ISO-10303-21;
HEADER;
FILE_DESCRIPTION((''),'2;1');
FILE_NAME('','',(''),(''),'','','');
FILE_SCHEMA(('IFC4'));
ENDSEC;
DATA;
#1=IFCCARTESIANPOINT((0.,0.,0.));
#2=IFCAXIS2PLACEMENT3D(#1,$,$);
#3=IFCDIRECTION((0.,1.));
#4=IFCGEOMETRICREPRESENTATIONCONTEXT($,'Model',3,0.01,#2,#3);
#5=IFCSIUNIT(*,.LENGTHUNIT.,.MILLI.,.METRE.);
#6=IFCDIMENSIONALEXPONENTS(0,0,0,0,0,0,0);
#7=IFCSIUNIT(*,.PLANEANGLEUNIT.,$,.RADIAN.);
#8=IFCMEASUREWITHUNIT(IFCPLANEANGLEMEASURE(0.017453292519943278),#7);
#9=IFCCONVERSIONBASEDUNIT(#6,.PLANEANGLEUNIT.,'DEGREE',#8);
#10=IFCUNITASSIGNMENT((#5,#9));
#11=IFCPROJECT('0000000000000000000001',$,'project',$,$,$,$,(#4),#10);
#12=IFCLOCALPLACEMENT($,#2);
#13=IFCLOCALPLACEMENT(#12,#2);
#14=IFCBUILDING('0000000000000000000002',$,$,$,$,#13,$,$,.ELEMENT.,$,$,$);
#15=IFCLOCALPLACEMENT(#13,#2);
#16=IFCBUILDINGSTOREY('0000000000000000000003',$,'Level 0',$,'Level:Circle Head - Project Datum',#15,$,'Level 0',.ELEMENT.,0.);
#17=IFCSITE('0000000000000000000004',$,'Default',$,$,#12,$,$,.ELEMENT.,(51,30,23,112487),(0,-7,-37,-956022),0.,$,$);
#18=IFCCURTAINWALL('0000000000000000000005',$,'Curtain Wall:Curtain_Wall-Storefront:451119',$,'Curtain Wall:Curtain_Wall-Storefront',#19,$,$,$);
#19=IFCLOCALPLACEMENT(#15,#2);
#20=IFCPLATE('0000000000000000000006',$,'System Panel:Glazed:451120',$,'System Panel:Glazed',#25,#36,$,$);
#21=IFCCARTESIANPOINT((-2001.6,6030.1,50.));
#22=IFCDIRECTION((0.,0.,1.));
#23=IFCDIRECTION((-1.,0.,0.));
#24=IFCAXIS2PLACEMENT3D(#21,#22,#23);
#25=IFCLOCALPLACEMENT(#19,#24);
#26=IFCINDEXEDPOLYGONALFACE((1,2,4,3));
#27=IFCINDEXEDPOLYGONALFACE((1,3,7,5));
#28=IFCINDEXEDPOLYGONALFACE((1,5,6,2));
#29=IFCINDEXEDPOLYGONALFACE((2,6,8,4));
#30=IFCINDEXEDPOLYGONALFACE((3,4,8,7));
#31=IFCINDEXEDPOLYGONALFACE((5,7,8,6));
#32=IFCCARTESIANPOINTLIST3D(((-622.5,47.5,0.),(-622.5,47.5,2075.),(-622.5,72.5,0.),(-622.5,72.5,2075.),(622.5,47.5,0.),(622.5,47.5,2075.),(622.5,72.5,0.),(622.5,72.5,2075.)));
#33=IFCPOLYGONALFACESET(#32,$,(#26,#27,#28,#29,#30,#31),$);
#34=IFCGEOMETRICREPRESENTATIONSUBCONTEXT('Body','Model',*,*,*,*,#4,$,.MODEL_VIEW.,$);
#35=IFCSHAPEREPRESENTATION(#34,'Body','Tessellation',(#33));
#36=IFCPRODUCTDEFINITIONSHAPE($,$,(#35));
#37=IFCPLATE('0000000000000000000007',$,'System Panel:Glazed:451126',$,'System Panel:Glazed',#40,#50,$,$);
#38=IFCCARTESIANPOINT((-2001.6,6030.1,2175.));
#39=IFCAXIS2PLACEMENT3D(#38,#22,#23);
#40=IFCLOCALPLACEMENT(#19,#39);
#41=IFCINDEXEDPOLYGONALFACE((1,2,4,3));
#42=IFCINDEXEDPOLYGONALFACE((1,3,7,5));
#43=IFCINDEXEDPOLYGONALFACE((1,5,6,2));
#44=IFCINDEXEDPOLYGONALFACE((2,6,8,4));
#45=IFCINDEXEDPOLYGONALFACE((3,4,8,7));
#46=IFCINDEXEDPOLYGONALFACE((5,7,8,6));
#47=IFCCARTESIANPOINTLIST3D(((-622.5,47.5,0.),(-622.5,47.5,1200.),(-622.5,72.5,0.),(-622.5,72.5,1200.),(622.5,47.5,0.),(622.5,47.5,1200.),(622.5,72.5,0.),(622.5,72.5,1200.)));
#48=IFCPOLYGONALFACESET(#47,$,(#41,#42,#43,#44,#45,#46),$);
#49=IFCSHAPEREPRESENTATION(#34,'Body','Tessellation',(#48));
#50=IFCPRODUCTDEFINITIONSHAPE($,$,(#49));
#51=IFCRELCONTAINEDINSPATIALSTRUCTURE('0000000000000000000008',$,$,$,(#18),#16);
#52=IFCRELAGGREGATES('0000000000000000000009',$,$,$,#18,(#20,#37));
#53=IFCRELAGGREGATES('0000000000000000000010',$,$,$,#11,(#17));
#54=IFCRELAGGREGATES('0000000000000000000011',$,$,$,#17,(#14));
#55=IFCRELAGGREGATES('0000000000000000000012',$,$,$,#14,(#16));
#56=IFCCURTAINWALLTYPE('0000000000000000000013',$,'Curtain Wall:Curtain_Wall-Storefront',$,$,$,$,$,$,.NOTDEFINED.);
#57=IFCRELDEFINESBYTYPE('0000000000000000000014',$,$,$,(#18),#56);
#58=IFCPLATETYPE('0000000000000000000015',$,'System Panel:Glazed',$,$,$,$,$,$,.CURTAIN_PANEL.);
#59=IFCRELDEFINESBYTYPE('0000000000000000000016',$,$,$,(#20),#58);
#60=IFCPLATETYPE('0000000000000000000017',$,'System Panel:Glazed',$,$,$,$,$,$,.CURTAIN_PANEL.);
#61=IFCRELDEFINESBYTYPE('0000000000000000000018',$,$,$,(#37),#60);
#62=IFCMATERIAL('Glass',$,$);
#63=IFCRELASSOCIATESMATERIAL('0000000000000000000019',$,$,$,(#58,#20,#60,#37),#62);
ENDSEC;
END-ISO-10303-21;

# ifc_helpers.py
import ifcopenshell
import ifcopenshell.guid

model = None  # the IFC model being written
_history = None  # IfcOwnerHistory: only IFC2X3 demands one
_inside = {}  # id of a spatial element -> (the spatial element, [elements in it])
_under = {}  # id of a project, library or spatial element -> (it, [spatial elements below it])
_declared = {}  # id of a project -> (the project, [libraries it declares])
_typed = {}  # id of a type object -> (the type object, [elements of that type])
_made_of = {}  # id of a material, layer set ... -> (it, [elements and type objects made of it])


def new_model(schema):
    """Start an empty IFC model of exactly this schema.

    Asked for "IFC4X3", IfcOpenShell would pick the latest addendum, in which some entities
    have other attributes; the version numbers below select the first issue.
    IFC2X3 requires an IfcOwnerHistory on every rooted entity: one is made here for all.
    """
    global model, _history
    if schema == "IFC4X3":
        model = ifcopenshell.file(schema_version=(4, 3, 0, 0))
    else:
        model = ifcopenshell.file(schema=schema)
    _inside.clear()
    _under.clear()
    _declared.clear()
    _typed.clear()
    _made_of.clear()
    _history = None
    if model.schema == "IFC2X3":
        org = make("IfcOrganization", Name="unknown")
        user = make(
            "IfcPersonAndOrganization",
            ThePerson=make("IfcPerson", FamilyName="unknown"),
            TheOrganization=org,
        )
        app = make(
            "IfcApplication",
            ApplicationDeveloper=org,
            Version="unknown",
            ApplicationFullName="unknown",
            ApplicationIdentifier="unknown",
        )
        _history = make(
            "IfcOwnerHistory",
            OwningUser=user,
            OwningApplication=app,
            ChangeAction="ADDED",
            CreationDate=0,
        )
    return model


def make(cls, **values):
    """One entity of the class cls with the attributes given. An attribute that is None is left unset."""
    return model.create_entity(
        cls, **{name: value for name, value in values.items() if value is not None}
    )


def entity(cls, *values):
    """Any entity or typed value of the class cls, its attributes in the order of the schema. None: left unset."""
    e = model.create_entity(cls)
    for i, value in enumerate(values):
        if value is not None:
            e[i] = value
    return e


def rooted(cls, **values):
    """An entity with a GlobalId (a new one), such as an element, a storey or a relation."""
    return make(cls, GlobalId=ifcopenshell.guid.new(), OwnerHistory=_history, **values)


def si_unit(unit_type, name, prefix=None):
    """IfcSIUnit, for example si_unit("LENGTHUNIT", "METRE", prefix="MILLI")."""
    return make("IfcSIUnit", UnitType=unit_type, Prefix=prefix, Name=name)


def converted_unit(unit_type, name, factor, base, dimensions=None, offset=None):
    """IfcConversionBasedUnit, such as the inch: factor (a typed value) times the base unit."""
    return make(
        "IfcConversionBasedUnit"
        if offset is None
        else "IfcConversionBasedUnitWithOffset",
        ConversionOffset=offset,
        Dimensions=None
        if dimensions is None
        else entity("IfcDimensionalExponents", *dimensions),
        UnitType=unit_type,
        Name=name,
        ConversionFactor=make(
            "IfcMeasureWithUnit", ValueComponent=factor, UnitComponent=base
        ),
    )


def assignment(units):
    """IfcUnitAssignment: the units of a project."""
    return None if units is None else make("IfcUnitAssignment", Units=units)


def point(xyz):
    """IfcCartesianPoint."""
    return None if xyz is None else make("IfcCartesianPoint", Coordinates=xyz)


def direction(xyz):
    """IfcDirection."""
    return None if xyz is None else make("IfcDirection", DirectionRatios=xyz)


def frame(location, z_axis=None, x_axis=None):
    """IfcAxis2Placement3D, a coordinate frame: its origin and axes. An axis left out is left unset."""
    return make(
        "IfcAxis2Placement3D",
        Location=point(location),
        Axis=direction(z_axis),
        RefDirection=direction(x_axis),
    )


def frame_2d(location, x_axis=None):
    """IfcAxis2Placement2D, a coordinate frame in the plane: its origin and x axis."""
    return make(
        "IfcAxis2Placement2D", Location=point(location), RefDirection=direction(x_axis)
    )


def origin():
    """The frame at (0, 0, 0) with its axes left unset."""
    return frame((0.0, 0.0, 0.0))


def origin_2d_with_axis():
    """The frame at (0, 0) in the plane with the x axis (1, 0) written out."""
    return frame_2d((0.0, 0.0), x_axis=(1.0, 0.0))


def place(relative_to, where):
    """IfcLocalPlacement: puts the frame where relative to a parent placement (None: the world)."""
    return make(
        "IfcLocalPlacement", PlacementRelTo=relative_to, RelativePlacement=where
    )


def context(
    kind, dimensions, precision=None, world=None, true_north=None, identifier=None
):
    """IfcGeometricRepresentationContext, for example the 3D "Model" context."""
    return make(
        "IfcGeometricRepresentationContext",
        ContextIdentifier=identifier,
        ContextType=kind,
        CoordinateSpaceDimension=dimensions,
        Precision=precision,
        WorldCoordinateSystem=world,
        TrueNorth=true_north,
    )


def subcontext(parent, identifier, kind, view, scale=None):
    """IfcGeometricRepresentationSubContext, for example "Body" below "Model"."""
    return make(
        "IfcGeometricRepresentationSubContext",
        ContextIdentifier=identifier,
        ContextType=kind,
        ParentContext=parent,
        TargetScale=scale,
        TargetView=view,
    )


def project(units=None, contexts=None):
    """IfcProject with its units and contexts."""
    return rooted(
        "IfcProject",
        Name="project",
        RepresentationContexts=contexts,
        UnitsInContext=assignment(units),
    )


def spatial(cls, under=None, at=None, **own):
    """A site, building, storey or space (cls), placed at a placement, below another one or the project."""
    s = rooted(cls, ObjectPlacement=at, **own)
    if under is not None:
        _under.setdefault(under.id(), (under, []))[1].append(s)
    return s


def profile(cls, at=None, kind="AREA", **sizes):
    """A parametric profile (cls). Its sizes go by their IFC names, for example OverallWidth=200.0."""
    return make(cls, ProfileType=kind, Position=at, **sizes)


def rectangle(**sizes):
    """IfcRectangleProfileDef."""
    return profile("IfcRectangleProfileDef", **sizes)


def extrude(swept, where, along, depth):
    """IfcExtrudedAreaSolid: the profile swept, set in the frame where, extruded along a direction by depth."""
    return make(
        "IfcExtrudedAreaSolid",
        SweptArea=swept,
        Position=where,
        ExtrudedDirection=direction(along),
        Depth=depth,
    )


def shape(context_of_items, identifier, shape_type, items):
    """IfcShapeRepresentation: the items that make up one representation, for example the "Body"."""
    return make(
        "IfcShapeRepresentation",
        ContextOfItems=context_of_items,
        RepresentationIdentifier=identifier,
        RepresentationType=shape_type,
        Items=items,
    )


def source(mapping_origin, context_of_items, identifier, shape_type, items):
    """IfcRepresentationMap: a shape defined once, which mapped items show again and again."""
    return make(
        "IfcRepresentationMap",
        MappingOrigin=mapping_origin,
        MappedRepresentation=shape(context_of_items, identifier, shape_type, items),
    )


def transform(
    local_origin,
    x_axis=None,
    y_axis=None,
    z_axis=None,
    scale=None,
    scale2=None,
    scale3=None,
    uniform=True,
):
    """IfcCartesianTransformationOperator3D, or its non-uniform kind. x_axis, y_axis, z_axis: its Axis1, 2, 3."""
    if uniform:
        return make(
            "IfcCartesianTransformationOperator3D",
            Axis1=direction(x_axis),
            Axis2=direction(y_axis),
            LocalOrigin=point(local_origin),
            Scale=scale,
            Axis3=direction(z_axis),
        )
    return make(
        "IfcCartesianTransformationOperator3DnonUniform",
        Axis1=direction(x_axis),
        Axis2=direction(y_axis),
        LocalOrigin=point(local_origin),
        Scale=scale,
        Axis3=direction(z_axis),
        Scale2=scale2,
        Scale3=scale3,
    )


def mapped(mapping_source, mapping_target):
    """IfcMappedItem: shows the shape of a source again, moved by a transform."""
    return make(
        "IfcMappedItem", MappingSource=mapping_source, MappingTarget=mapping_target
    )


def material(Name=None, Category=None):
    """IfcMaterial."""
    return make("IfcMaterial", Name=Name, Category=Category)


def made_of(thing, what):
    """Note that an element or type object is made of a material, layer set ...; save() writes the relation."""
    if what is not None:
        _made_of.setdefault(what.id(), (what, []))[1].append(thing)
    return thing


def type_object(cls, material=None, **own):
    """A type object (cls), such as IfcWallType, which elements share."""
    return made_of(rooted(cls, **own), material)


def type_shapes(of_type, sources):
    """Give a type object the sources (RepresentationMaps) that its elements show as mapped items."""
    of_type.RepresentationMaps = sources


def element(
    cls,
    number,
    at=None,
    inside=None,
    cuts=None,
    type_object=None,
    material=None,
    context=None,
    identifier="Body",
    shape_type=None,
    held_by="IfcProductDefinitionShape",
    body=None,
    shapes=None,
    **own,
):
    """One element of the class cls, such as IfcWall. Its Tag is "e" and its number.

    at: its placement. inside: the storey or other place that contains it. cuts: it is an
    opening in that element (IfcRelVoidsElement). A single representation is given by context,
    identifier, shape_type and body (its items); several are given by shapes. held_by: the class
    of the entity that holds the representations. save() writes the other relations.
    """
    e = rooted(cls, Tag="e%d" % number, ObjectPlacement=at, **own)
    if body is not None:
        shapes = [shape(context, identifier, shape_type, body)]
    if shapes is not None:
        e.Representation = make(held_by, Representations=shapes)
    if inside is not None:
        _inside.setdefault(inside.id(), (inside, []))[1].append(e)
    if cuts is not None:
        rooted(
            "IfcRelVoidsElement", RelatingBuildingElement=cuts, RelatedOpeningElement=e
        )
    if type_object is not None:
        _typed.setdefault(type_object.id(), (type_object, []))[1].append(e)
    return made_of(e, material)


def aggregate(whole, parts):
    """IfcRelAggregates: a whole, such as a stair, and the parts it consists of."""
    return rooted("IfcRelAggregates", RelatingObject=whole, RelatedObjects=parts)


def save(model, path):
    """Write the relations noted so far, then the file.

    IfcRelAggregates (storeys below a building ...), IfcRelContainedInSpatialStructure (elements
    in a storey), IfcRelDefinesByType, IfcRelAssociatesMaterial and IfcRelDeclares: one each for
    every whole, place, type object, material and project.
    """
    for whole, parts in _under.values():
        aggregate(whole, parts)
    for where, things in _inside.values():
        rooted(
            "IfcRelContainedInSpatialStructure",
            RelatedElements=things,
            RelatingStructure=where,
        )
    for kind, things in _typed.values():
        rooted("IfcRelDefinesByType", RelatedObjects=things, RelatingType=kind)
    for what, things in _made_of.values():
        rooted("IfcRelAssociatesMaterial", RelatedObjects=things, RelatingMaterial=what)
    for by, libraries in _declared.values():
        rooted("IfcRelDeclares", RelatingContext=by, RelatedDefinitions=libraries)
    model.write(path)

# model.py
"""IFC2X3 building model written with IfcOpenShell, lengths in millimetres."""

from ifc_helpers import new_model, entity, si_unit, converted_unit, direction, frame, origin, origin_2d_with_axis, place, context, subcontext, project, spatial, rectangle, extrude, source, transform, mapped, material, type_object, type_shapes, element, aggregate, save


model = new_model("IFC2X3")

# Units and contexts
model_context = context("Model", 3, precision=0.01, world=origin(), true_north=direction((0.0, 1.0)))
body_context = subcontext(model_context, "Body", "Model", "MODEL_VIEW")
ifc_project = project(units=[si_unit("LENGTHUNIT", "METRE", prefix="MILLI"), converted_unit("PLANEANGLEUNIT", "DEGREE", entity("IfcPlaneAngleMeasure", 0.017453292519943278), si_unit("PLANEANGLEUNIT", "RADIAN"), dimensions=[0, 0, 0, 0, 0, 0, 0])], contexts=[model_context])

# Site, building, storey
site_placement = place(None, origin())
site = spatial("IfcSite", under=ifc_project, at=site_placement, Name="Default", CompositionType="ELEMENT", RefLatitude=(51, 30, 23, 112487), RefLongitude=(0, -7, -37, -956022), RefElevation=0.0)
building_placement = place(site_placement, origin())
building = spatial("IfcBuilding", under=site, at=building_placement, CompositionType="ELEMENT")
storey_placement = place(building_placement, origin())
storey = spatial("IfcBuildingStorey", under=building, at=storey_placement, Name="Level 0", ObjectType="Level:Circle Head - Project Datum", LongName="Level 0", CompositionType="ELEMENT", Elevation=0.0)

# Curtain wall
curtain_wall_type = type_object("IfcCurtainWallType", Name="Curtain Wall:Curtain_Wall-Storefront", PredefinedType="NOTDEFINED")
curtain_wall_placement = place(storey_placement, origin())
curtain_wall = element("IfcCurtainWall", 1, at=curtain_wall_placement, inside=storey, type_object=curtain_wall_type, Name="Curtain Wall:Curtain_Wall-Storefront:451119", ObjectType="Curtain Wall:Curtain_Wall-Storefront")

# Plates
ifc_material_1 = material(Name="Glass")
plate_type_1 = type_object("IfcPlateType", Name="System Panel:Glazed", PredefinedType="CURTAIN_PANEL", material=ifc_material_1)
shared_shape_1 = source(origin(), body_context, "Body", "SweptSolid", [
    extrude(rectangle(XDim=25.0, YDim=1245.0, at=origin_2d_with_axis()), frame((0.0, 60.0, 0.0), z_axis=(0.0, 0.0, 1.0), x_axis=(0.0, 1.0, 0.0)), (0.0, 0.0, 1.0), 2075.0),
])
type_shapes(plate_type_1, [shared_shape_1])
plate_1_placement = place(curtain_wall_placement, frame((-2001.6, 6030.1, 50.0), z_axis=(0.0, 0.0, 1.0), x_axis=(-1.0, 0.0, 0.0)))
plate_1 = element("IfcPlate", 2, at=plate_1_placement, type_object=plate_type_1, material=ifc_material_1, Name="System Panel:Glazed:451120", ObjectType="System Panel:Glazed", context=body_context, shape_type="MappedRepresentation", body=[
    mapped(shared_shape_1, transform((0.0, 0.0, 0.0), scale=1.0)),
])
plate_type_2 = type_object("IfcPlateType", Name="System Panel:Glazed", PredefinedType="CURTAIN_PANEL", material=ifc_material_1)
shared_shape_2 = source(origin(), body_context, "Body", "SweptSolid", [
    extrude(rectangle(XDim=25.0, YDim=1245.0, at=origin_2d_with_axis()), frame((0.0, 60.0, 0.0), z_axis=(0.0, 0.0, 1.0), x_axis=(0.0, 1.0, 0.0)), (0.0, 0.0, 1.0), 1200.0),
])
type_shapes(plate_type_2, [shared_shape_2])
plate_2_placement = place(curtain_wall_placement, frame((-2001.6, 6030.1, 2175.0), z_axis=(0.0, 0.0, 1.0), x_axis=(-1.0, 0.0, 0.0)))
plate_2 = element("IfcPlate", 3, at=plate_2_placement, type_object=plate_type_2, material=ifc_material_1, Name="System Panel:Glazed:451126", ObjectType="System Panel:Glazed", context=body_context, shape_type="MappedRepresentation", body=[
    mapped(shared_shape_2, transform((0.0, 0.0, 0.0), scale=1.0)),
])
aggregate(curtain_wall, [plate_1, plate_2])

save(model, "model.ifc")
